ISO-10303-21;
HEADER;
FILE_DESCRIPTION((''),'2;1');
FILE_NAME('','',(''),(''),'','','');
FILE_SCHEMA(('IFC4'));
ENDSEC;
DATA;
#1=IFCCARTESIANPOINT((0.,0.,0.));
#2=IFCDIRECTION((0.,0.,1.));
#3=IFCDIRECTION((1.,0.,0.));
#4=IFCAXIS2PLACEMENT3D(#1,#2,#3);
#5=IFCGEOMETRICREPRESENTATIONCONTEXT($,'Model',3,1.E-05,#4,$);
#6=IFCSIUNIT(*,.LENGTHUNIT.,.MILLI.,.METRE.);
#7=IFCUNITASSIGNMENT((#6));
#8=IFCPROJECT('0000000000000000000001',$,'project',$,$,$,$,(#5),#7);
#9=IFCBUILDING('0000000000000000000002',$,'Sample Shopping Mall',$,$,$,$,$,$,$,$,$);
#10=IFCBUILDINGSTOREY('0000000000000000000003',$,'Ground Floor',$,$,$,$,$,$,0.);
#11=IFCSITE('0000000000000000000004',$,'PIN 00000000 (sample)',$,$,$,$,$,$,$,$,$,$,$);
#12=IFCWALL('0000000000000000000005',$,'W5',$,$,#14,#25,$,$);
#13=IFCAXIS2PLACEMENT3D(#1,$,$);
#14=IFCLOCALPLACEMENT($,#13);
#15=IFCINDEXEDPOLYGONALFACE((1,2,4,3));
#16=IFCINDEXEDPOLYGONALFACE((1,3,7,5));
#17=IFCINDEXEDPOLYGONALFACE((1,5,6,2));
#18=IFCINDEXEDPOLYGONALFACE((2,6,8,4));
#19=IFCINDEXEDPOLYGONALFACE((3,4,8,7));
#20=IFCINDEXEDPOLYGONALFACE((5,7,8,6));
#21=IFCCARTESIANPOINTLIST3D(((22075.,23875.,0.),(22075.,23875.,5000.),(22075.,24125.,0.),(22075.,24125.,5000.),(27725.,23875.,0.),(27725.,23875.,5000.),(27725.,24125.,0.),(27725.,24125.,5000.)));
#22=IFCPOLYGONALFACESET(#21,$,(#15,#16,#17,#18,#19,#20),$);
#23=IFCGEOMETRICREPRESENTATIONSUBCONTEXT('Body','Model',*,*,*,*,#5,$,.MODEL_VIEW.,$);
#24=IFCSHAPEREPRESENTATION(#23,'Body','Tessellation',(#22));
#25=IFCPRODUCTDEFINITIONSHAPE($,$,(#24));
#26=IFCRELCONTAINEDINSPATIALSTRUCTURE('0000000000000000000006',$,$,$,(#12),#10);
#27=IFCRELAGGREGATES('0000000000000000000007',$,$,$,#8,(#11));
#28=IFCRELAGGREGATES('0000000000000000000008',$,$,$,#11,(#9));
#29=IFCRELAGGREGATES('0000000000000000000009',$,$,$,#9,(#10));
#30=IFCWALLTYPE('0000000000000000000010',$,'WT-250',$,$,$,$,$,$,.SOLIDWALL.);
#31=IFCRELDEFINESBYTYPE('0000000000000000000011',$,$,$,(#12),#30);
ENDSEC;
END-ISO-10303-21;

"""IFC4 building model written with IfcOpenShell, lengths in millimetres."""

from ifc_helpers import new_model, si_unit, frame, origin_with_axes, place, context, subcontext, project, spatial, indexed_curve, outline, extrude, type_object, element, save


model = new_model("IFC4")

# Units and contexts
model_context = context("Model", 3, precision=1e-05, world=origin_with_axes())
body_context = subcontext(model_context, "Body", "Model", "MODEL_VIEW")
ifc_project = project(units=[si_unit("LENGTHUNIT", "METRE", prefix="MILLI")], contexts=[model_context])

# Site, building, storey
site = spatial("IfcSite", under=ifc_project, Name="PIN 00000000 (sample)")
building = spatial("IfcBuilding", under=site, Name="Sample Shopping Mall")
storey = spatial("IfcBuildingStorey", under=building, Name="Ground Floor", Elevation=0.0)

# Wall
wall_type_1 = type_object("IfcWallType", Name="WT-250", PredefinedType="SOLIDWALL")
wall_1_placement = place(None, frame((22075.0, 23875.0, 0.0), z_axis=(0.0, 0.0, 1.0), x_axis=(1.0, 0.0, 0.0)))
element("IfcWall", 1, at=wall_1_placement, inside=storey, type_object=wall_type_1, Name="W5", context=body_context, shape_type="SweptSolid", body=[
    extrude(outline(indexed_curve([(0.0, 0.0), (0.0, 250.0), (5650.0, 250.0), (5650.0, 0.0), (0.0, 0.0)], self_intersect=False)), origin_with_axes(), (0.0, 0.0, 1.0), 5000.0),
])

save(model, "model.ifc")
